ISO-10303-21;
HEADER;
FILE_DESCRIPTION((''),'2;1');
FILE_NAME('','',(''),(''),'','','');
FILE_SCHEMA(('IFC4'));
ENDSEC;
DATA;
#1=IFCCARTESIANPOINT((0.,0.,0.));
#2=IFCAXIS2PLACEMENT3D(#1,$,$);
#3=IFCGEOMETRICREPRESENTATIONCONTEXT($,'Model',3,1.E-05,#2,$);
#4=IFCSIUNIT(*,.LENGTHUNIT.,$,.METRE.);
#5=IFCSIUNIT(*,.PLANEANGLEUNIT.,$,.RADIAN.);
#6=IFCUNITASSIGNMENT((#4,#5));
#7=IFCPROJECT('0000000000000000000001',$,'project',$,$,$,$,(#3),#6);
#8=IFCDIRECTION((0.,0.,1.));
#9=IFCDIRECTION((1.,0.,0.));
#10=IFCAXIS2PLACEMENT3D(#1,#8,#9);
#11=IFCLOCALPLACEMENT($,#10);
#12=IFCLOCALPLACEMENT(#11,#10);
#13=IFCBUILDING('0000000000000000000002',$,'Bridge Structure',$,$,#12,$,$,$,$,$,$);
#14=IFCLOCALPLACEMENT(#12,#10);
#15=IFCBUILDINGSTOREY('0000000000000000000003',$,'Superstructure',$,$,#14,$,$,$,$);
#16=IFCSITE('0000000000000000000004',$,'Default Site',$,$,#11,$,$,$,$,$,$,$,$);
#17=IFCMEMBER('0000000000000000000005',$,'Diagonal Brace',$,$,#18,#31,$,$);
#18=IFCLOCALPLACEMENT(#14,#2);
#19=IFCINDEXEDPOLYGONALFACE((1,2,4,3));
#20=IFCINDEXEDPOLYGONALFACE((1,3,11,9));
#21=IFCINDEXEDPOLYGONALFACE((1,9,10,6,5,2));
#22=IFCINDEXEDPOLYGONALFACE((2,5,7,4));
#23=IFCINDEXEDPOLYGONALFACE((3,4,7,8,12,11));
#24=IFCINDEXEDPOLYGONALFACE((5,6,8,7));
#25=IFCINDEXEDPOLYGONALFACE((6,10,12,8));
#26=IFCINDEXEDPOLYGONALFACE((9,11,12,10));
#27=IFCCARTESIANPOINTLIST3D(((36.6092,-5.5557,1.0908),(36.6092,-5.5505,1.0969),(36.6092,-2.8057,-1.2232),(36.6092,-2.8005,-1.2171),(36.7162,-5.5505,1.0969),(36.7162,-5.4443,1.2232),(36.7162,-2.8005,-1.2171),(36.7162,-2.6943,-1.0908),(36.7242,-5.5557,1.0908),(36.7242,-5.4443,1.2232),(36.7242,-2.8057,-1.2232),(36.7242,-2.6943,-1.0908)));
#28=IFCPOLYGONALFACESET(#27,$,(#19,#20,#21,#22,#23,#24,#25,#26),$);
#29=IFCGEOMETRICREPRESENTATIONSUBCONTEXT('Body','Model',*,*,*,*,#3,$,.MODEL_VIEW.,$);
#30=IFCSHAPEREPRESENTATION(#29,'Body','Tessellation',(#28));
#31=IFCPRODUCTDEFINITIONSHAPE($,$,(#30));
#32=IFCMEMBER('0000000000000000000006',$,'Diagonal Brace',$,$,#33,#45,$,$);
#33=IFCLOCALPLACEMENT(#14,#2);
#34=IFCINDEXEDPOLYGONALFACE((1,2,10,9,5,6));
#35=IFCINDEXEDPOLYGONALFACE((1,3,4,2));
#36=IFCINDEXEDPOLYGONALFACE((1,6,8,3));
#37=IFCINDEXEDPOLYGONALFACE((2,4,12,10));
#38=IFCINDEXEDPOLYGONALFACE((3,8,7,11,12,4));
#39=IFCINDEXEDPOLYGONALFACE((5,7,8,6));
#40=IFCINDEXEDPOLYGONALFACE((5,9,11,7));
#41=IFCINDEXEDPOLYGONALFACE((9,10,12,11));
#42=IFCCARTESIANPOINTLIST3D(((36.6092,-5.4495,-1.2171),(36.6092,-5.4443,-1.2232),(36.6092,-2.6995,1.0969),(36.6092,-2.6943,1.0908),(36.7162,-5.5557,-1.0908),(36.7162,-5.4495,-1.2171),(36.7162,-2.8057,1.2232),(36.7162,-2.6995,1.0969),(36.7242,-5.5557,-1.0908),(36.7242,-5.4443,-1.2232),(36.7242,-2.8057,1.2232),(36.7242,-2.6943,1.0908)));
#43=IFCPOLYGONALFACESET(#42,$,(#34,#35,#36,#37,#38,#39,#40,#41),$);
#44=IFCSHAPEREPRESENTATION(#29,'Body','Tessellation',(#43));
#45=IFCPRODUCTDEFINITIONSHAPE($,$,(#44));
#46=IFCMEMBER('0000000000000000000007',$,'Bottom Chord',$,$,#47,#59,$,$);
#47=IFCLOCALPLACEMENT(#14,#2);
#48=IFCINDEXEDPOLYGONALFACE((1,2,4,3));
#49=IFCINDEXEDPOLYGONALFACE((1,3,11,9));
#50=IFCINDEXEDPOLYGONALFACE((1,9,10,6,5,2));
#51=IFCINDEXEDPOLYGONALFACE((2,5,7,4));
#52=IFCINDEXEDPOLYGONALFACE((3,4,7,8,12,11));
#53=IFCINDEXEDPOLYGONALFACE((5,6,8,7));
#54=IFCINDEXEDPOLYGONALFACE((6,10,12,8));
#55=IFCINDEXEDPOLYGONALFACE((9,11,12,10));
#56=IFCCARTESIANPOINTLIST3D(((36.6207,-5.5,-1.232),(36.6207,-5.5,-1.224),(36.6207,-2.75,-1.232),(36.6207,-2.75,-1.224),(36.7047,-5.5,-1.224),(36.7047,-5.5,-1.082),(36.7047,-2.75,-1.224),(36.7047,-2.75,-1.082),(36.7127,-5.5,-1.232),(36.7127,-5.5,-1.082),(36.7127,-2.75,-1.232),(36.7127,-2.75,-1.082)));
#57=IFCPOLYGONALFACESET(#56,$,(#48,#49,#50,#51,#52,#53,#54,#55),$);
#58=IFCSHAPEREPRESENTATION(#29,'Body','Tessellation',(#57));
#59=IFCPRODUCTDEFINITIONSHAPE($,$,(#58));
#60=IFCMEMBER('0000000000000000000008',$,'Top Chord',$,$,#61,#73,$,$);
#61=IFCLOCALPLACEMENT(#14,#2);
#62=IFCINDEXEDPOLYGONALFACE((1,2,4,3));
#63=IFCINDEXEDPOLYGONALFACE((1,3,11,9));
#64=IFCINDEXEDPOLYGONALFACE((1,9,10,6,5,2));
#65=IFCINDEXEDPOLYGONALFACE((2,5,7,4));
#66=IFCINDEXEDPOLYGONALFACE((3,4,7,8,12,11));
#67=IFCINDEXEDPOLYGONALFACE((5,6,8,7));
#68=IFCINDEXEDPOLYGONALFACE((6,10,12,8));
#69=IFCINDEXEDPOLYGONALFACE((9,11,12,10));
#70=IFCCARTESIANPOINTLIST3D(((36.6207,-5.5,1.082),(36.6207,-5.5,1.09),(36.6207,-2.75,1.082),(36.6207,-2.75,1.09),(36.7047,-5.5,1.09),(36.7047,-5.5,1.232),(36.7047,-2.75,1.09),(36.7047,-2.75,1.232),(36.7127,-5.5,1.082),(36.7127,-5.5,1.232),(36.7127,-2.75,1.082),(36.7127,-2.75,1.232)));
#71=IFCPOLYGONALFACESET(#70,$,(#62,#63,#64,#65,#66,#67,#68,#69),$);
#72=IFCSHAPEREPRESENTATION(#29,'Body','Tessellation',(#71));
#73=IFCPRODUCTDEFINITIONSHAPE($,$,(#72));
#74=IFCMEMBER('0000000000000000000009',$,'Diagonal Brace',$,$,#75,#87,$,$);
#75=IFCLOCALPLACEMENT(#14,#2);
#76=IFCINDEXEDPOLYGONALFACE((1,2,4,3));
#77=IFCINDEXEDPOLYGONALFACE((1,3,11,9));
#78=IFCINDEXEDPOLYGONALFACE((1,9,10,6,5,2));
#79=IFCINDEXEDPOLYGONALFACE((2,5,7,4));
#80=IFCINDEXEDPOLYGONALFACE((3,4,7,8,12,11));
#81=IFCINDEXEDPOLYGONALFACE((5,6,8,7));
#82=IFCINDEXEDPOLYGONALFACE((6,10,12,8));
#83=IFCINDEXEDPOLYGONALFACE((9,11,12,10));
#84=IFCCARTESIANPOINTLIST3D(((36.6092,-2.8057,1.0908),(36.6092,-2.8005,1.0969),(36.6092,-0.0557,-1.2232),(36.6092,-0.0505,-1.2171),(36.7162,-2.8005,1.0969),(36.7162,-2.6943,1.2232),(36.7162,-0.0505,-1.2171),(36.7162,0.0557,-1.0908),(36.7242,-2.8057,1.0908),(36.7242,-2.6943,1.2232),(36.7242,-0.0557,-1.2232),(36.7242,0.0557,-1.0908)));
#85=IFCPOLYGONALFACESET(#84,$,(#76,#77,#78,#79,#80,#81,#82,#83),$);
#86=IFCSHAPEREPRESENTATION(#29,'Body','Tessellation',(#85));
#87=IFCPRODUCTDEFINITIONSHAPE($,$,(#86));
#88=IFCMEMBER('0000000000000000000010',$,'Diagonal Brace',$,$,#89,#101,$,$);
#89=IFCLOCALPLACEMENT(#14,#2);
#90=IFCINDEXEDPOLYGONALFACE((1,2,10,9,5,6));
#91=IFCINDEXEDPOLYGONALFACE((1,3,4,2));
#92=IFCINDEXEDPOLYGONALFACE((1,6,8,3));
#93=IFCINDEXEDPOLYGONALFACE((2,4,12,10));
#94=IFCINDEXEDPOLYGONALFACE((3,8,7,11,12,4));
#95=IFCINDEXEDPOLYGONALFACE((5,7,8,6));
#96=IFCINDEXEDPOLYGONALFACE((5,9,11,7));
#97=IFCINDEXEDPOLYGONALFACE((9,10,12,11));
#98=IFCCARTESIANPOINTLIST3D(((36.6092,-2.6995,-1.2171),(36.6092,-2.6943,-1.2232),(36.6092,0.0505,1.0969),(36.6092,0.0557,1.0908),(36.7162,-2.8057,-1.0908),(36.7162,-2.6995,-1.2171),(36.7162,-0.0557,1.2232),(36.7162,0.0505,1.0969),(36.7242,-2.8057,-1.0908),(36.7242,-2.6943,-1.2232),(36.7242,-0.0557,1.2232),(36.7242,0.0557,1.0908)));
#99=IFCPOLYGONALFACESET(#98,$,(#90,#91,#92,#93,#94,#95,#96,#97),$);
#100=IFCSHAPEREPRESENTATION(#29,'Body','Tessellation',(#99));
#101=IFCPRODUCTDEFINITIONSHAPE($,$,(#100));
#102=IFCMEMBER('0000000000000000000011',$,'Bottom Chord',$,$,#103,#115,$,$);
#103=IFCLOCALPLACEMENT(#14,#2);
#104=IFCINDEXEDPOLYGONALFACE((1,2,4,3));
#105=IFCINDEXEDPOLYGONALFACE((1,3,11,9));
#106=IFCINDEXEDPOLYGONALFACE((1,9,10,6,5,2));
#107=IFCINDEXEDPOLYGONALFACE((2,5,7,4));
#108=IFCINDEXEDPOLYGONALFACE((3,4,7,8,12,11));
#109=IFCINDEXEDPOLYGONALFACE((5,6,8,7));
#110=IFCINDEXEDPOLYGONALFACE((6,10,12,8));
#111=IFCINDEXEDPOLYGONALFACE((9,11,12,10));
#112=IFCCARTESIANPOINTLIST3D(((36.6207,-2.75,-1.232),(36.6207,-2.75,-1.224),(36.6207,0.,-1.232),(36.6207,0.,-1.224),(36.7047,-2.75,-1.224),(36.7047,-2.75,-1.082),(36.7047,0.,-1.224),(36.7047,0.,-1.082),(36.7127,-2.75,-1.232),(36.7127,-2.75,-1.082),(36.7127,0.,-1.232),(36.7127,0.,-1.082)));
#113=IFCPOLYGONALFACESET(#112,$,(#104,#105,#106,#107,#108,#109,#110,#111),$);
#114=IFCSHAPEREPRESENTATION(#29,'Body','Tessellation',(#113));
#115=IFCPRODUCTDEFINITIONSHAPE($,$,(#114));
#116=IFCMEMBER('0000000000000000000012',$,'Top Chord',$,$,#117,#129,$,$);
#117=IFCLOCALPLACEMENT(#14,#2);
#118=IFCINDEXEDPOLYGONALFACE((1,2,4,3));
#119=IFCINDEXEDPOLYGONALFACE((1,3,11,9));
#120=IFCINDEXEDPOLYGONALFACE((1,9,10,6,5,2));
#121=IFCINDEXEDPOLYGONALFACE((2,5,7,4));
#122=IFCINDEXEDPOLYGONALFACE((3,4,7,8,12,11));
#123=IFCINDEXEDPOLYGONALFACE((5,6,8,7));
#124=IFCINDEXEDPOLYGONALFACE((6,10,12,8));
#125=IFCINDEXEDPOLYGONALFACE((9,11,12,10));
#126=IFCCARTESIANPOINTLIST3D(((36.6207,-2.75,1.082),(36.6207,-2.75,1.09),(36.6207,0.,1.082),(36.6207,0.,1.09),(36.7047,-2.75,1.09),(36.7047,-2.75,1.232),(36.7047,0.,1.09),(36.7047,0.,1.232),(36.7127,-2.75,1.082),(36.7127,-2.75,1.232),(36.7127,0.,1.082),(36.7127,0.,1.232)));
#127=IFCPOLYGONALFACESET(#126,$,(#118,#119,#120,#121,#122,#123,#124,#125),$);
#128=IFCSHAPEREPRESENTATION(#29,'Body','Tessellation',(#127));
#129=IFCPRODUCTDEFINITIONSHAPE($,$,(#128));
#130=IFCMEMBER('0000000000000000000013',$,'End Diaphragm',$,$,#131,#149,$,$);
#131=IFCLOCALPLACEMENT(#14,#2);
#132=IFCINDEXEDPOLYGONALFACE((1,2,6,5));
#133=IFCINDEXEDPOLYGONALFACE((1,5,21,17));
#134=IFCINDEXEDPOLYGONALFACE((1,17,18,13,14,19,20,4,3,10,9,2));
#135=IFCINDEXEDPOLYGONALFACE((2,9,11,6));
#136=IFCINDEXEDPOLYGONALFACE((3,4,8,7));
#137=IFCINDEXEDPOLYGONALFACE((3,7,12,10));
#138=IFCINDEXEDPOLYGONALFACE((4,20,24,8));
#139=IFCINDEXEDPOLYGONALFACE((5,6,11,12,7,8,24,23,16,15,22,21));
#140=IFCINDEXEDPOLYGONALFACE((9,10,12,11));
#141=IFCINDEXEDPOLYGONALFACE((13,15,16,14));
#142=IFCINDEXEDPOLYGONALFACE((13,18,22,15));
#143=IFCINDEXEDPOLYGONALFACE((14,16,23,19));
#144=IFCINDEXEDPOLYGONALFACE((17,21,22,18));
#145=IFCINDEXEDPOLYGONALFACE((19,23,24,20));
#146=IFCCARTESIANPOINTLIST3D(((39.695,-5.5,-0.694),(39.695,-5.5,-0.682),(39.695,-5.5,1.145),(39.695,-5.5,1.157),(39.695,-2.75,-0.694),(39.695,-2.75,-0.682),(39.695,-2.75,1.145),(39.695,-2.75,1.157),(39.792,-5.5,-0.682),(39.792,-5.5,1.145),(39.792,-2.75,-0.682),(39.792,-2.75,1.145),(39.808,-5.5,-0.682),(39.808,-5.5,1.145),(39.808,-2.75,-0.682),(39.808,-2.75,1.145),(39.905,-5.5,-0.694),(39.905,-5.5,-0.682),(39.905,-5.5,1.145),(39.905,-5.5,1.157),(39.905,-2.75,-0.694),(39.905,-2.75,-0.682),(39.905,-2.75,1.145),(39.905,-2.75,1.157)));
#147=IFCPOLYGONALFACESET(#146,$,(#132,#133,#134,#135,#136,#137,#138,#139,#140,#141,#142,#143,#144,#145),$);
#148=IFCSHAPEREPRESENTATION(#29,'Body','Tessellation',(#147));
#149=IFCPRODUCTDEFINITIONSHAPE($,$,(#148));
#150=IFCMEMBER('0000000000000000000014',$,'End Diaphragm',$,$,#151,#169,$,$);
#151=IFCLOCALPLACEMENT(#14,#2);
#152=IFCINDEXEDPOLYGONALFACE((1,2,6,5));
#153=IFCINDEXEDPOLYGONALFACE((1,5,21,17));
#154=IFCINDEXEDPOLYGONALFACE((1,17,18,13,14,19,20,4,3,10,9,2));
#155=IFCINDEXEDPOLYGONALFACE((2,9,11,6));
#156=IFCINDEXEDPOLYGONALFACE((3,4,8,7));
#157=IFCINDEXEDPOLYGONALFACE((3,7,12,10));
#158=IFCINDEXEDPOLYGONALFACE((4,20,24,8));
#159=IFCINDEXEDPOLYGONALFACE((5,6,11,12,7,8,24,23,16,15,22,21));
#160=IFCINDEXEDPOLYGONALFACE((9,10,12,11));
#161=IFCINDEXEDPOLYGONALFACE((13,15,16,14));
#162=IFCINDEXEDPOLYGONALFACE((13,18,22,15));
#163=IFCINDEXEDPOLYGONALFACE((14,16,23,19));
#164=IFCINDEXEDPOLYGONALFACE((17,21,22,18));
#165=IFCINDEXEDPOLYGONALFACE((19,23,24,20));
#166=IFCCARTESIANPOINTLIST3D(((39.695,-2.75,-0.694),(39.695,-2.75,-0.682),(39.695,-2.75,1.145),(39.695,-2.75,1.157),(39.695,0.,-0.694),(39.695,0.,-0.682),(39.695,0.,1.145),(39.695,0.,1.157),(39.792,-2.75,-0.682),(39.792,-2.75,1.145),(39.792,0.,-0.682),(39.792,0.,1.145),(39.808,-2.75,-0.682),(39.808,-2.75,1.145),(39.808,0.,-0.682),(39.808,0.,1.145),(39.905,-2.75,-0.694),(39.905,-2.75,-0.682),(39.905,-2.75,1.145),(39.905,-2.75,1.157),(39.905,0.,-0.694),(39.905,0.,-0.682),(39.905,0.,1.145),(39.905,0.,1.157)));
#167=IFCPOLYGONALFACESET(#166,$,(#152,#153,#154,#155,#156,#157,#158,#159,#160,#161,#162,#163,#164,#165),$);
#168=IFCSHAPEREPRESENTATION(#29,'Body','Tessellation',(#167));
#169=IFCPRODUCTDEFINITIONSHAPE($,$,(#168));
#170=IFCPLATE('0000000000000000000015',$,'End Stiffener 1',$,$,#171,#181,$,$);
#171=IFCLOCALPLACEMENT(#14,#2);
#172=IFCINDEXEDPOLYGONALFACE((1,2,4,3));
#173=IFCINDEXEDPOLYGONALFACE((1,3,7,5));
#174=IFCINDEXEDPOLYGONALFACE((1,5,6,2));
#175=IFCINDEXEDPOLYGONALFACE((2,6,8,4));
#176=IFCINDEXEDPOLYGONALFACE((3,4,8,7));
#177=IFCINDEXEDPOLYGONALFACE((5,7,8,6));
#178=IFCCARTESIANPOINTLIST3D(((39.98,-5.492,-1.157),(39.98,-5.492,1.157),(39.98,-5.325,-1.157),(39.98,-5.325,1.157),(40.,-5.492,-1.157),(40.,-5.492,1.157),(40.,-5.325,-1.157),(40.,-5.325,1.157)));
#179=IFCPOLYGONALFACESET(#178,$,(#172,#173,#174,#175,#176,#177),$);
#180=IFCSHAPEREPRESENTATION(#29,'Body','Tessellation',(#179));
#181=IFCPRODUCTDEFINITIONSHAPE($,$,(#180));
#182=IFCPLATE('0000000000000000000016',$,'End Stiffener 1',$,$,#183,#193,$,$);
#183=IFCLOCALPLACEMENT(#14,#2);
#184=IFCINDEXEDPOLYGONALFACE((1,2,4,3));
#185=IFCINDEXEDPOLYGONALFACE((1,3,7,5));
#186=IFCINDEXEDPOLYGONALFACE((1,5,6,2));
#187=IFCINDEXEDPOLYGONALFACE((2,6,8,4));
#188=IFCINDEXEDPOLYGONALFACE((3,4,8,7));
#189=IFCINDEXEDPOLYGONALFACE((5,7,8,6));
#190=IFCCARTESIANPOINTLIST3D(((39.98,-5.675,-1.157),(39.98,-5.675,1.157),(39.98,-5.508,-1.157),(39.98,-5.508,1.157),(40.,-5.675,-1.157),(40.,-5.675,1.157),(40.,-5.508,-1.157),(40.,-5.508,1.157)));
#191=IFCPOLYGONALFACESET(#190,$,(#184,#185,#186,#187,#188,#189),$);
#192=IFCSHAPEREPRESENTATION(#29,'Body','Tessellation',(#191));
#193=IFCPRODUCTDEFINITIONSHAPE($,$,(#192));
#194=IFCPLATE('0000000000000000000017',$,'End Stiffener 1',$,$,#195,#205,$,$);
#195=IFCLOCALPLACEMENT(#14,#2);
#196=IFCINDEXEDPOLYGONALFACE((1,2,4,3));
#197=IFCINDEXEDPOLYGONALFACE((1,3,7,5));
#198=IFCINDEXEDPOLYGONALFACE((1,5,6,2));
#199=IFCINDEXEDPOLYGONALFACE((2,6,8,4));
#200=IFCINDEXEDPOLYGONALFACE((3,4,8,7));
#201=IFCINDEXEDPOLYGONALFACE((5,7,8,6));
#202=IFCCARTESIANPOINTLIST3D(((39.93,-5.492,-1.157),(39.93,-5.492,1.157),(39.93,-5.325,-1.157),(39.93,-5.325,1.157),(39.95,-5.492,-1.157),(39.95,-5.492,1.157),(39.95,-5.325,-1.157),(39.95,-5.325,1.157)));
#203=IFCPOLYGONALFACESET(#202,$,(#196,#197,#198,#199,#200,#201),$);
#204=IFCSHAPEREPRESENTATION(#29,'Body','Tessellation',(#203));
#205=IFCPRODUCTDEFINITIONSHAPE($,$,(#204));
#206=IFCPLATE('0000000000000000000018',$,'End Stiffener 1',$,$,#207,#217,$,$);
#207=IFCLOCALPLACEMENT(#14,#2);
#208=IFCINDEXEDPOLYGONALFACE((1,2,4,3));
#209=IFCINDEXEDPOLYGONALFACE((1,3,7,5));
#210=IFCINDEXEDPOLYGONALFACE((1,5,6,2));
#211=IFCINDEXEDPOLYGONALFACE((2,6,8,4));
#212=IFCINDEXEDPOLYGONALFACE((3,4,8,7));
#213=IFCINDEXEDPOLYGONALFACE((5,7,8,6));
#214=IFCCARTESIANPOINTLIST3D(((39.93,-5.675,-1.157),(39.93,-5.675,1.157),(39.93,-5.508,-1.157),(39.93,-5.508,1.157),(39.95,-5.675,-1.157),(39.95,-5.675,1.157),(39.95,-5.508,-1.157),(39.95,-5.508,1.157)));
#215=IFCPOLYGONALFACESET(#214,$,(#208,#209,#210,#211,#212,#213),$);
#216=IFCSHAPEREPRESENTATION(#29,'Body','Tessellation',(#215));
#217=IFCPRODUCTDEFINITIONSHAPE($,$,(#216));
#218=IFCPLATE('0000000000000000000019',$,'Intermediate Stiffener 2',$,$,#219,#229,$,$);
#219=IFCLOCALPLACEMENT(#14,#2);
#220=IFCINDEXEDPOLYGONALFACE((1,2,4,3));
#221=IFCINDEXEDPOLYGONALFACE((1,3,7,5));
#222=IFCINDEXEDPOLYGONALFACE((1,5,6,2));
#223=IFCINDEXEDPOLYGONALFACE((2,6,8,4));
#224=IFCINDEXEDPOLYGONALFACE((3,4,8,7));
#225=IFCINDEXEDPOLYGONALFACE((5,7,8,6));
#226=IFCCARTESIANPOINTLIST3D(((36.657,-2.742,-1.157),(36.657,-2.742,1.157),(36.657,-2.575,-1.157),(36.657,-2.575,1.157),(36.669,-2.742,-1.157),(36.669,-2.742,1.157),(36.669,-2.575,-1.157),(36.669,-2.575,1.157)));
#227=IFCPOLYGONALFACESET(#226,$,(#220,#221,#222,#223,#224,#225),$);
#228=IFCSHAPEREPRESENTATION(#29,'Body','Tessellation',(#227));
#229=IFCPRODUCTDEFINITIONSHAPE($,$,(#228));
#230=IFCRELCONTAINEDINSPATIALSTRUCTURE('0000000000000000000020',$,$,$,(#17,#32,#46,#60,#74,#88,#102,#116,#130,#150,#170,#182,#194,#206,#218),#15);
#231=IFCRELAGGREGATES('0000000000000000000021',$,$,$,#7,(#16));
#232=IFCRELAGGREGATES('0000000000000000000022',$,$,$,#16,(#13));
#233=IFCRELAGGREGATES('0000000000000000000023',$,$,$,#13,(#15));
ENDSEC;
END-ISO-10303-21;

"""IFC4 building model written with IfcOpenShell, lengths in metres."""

from ifc_helpers import new_model, si_unit, frame, origin, origin_with_axes, origin_2d_with_axis, place, context, subcontext, project, spatial, rectangle, i_section, l_section, extrude, element, save


model = new_model("IFC4")

# Units and contexts
model_context = context("Model", 3, precision=1e-05, world=origin())
body_context = subcontext(model_context, "Body", "Model", "MODEL_VIEW")
ifc_project = project(units=[si_unit("LENGTHUNIT", "METRE"), si_unit("PLANEANGLEUNIT", "RADIAN")], contexts=[model_context])

# Site, building, storey
site_placement = place(None, origin_with_axes())
site = spatial("IfcSite", under=ifc_project, at=site_placement, Name="Default Site")
building_placement = place(site_placement, origin_with_axes())
building = spatial("IfcBuilding", under=site, at=building_placement, Name="Bridge Structure")
storey_placement = place(building_placement, origin_with_axes())
storey = spatial("IfcBuildingStorey", under=building, at=storey_placement, Name="Superstructure")

# Members
for number, where, z_axis, x_axis, name in (
    (1, (36.6667, -5.5, 1.157), (0.0, 0.765156, -0.643844), (-1.0, 0.0, 0.0), "Diagonal Brace"),
    (2, (36.6667, -5.5, -1.157), (0.0, 0.765156, 0.643844), (-1.0, 0.0, 0.0), "Diagonal Brace"),
):
    element("IfcMember", number, at=place(storey_placement, frame(where, z_axis=z_axis, x_axis=x_axis)), inside=storey, Name=name, context=body_context, shape_type="SweptSolid", body=[
        extrude(l_section(Depth=0.173, Width=0.115, Thickness=0.008, at=origin_2d_with_axis()), origin_with_axes(), (0.0, 0.0, 1.0), 3.594),
    ])
for number, where, z_axis, x_axis, name in (
    (3, (36.6667, -5.5, -1.157), (0.0, 1.0, 0.0), (-1.0, 0.0, 0.0), "Bottom Chord"),
    (4, (36.6667, -5.5, 1.157), (0.0, 1.0, 0.0), (-1.0, 0.0, 0.0), "Top Chord"),
):
    element("IfcMember", number, at=place(storey_placement, frame(where, z_axis=z_axis, x_axis=x_axis)), inside=storey, Name=name, context=body_context, shape_type="SweptSolid", body=[
        extrude(l_section(Depth=0.15, Width=0.092, Thickness=0.008, at=origin_2d_with_axis()), origin_with_axes(), (0.0, 0.0, 1.0), 2.75),
    ])
for number, where, z_axis, x_axis, name in (
    (5, (36.6667, -2.75, 1.157), (0.0, 0.765156, -0.643844), (-1.0, 0.0, 0.0), "Diagonal Brace"),
    (6, (36.6667, -2.75, -1.157), (0.0, 0.765156, 0.643844), (-1.0, 0.0, 0.0), "Diagonal Brace"),
):
    element("IfcMember", number, at=place(storey_placement, frame(where, z_axis=z_axis, x_axis=x_axis)), inside=storey, Name=name, context=body_context, shape_type="SweptSolid", body=[
        extrude(l_section(Depth=0.173, Width=0.115, Thickness=0.008, at=origin_2d_with_axis()), origin_with_axes(), (0.0, 0.0, 1.0), 3.594),
    ])
for number, where, z_axis, x_axis, name in (
    (7, (36.6667, -2.75, -1.157), (0.0, 1.0, 0.0), (-1.0, 0.0, 0.0), "Bottom Chord"),
    (8, (36.6667, -2.75, 1.157), (0.0, 1.0, 0.0), (-1.0, 0.0, 0.0), "Top Chord"),
):
    element("IfcMember", number, at=place(storey_placement, frame(where, z_axis=z_axis, x_axis=x_axis)), inside=storey, Name=name, context=body_context, shape_type="SweptSolid", body=[
        extrude(l_section(Depth=0.15, Width=0.092, Thickness=0.008, at=origin_2d_with_axis()), origin_with_axes(), (0.0, 0.0, 1.0), 2.75),
    ])
for number, where, z_axis, x_axis, name in (
    (9, (39.8, -5.5, 0.2315), (0.0, 1.0, 0.0), (-1.0, 0.0, 0.0), "End Diaphragm"),
    (10, (39.8, -2.75, 0.2315), (0.0, 1.0, 0.0), (-1.0, 0.0, 0.0), "End Diaphragm"),
):
    element("IfcMember", number, at=place(storey_placement, frame(where, z_axis=z_axis, x_axis=x_axis)), inside=storey, Name=name, context=body_context, shape_type="SweptSolid", body=[
        extrude(i_section(OverallWidth=0.21, OverallDepth=1.851, WebThickness=0.016, FlangeThickness=0.012, at=origin_2d_with_axis()), origin_with_axes(), (0.0, 0.0, 1.0), 2.75),
    ])

# Plates
for number, where, z_axis, x_axis, name in (
    (11, (39.99, -5.4085, -1.157), (0.0, 0.0, 1.0), (1.0, 0.0, 0.0), "End Stiffener 1"),
    (12, (39.99, -5.5915, -1.157), (0.0, 0.0, 1.0), (1.0, 0.0, 0.0), "End Stiffener 1"),
    (13, (39.94, -5.4085, -1.157), (0.0, 0.0, 1.0), (1.0, 0.0, 0.0), "End Stiffener 1"),
    (14, (39.94, -5.5915, -1.157), (0.0, 0.0, 1.0), (1.0, 0.0, 0.0), "End Stiffener 1"),
):
    element("IfcPlate", number, at=place(storey_placement, frame(where, z_axis=z_axis, x_axis=x_axis)), inside=storey, Name=name, context=body_context, shape_type="SweptSolid", body=[
        extrude(rectangle(XDim=0.02, YDim=0.167, at=origin_2d_with_axis()), origin_with_axes(), (0.0, 0.0, 1.0), 2.314),
    ])
plate_1_placement = place(storey_placement, frame((36.663, -2.6585, -1.157), z_axis=(0.0, 0.0, 1.0), x_axis=(1.0, 0.0, 0.0)))
element("IfcPlate", 15, at=plate_1_placement, inside=storey, Name="Intermediate Stiffener 2", context=body_context, shape_type="SweptSolid", body=[
    extrude(rectangle(XDim=0.012, YDim=0.167, at=origin_2d_with_axis()), origin_with_axes(), (0.0, 0.0, 1.0), 2.314),
])

save(model, "model.ifc")
